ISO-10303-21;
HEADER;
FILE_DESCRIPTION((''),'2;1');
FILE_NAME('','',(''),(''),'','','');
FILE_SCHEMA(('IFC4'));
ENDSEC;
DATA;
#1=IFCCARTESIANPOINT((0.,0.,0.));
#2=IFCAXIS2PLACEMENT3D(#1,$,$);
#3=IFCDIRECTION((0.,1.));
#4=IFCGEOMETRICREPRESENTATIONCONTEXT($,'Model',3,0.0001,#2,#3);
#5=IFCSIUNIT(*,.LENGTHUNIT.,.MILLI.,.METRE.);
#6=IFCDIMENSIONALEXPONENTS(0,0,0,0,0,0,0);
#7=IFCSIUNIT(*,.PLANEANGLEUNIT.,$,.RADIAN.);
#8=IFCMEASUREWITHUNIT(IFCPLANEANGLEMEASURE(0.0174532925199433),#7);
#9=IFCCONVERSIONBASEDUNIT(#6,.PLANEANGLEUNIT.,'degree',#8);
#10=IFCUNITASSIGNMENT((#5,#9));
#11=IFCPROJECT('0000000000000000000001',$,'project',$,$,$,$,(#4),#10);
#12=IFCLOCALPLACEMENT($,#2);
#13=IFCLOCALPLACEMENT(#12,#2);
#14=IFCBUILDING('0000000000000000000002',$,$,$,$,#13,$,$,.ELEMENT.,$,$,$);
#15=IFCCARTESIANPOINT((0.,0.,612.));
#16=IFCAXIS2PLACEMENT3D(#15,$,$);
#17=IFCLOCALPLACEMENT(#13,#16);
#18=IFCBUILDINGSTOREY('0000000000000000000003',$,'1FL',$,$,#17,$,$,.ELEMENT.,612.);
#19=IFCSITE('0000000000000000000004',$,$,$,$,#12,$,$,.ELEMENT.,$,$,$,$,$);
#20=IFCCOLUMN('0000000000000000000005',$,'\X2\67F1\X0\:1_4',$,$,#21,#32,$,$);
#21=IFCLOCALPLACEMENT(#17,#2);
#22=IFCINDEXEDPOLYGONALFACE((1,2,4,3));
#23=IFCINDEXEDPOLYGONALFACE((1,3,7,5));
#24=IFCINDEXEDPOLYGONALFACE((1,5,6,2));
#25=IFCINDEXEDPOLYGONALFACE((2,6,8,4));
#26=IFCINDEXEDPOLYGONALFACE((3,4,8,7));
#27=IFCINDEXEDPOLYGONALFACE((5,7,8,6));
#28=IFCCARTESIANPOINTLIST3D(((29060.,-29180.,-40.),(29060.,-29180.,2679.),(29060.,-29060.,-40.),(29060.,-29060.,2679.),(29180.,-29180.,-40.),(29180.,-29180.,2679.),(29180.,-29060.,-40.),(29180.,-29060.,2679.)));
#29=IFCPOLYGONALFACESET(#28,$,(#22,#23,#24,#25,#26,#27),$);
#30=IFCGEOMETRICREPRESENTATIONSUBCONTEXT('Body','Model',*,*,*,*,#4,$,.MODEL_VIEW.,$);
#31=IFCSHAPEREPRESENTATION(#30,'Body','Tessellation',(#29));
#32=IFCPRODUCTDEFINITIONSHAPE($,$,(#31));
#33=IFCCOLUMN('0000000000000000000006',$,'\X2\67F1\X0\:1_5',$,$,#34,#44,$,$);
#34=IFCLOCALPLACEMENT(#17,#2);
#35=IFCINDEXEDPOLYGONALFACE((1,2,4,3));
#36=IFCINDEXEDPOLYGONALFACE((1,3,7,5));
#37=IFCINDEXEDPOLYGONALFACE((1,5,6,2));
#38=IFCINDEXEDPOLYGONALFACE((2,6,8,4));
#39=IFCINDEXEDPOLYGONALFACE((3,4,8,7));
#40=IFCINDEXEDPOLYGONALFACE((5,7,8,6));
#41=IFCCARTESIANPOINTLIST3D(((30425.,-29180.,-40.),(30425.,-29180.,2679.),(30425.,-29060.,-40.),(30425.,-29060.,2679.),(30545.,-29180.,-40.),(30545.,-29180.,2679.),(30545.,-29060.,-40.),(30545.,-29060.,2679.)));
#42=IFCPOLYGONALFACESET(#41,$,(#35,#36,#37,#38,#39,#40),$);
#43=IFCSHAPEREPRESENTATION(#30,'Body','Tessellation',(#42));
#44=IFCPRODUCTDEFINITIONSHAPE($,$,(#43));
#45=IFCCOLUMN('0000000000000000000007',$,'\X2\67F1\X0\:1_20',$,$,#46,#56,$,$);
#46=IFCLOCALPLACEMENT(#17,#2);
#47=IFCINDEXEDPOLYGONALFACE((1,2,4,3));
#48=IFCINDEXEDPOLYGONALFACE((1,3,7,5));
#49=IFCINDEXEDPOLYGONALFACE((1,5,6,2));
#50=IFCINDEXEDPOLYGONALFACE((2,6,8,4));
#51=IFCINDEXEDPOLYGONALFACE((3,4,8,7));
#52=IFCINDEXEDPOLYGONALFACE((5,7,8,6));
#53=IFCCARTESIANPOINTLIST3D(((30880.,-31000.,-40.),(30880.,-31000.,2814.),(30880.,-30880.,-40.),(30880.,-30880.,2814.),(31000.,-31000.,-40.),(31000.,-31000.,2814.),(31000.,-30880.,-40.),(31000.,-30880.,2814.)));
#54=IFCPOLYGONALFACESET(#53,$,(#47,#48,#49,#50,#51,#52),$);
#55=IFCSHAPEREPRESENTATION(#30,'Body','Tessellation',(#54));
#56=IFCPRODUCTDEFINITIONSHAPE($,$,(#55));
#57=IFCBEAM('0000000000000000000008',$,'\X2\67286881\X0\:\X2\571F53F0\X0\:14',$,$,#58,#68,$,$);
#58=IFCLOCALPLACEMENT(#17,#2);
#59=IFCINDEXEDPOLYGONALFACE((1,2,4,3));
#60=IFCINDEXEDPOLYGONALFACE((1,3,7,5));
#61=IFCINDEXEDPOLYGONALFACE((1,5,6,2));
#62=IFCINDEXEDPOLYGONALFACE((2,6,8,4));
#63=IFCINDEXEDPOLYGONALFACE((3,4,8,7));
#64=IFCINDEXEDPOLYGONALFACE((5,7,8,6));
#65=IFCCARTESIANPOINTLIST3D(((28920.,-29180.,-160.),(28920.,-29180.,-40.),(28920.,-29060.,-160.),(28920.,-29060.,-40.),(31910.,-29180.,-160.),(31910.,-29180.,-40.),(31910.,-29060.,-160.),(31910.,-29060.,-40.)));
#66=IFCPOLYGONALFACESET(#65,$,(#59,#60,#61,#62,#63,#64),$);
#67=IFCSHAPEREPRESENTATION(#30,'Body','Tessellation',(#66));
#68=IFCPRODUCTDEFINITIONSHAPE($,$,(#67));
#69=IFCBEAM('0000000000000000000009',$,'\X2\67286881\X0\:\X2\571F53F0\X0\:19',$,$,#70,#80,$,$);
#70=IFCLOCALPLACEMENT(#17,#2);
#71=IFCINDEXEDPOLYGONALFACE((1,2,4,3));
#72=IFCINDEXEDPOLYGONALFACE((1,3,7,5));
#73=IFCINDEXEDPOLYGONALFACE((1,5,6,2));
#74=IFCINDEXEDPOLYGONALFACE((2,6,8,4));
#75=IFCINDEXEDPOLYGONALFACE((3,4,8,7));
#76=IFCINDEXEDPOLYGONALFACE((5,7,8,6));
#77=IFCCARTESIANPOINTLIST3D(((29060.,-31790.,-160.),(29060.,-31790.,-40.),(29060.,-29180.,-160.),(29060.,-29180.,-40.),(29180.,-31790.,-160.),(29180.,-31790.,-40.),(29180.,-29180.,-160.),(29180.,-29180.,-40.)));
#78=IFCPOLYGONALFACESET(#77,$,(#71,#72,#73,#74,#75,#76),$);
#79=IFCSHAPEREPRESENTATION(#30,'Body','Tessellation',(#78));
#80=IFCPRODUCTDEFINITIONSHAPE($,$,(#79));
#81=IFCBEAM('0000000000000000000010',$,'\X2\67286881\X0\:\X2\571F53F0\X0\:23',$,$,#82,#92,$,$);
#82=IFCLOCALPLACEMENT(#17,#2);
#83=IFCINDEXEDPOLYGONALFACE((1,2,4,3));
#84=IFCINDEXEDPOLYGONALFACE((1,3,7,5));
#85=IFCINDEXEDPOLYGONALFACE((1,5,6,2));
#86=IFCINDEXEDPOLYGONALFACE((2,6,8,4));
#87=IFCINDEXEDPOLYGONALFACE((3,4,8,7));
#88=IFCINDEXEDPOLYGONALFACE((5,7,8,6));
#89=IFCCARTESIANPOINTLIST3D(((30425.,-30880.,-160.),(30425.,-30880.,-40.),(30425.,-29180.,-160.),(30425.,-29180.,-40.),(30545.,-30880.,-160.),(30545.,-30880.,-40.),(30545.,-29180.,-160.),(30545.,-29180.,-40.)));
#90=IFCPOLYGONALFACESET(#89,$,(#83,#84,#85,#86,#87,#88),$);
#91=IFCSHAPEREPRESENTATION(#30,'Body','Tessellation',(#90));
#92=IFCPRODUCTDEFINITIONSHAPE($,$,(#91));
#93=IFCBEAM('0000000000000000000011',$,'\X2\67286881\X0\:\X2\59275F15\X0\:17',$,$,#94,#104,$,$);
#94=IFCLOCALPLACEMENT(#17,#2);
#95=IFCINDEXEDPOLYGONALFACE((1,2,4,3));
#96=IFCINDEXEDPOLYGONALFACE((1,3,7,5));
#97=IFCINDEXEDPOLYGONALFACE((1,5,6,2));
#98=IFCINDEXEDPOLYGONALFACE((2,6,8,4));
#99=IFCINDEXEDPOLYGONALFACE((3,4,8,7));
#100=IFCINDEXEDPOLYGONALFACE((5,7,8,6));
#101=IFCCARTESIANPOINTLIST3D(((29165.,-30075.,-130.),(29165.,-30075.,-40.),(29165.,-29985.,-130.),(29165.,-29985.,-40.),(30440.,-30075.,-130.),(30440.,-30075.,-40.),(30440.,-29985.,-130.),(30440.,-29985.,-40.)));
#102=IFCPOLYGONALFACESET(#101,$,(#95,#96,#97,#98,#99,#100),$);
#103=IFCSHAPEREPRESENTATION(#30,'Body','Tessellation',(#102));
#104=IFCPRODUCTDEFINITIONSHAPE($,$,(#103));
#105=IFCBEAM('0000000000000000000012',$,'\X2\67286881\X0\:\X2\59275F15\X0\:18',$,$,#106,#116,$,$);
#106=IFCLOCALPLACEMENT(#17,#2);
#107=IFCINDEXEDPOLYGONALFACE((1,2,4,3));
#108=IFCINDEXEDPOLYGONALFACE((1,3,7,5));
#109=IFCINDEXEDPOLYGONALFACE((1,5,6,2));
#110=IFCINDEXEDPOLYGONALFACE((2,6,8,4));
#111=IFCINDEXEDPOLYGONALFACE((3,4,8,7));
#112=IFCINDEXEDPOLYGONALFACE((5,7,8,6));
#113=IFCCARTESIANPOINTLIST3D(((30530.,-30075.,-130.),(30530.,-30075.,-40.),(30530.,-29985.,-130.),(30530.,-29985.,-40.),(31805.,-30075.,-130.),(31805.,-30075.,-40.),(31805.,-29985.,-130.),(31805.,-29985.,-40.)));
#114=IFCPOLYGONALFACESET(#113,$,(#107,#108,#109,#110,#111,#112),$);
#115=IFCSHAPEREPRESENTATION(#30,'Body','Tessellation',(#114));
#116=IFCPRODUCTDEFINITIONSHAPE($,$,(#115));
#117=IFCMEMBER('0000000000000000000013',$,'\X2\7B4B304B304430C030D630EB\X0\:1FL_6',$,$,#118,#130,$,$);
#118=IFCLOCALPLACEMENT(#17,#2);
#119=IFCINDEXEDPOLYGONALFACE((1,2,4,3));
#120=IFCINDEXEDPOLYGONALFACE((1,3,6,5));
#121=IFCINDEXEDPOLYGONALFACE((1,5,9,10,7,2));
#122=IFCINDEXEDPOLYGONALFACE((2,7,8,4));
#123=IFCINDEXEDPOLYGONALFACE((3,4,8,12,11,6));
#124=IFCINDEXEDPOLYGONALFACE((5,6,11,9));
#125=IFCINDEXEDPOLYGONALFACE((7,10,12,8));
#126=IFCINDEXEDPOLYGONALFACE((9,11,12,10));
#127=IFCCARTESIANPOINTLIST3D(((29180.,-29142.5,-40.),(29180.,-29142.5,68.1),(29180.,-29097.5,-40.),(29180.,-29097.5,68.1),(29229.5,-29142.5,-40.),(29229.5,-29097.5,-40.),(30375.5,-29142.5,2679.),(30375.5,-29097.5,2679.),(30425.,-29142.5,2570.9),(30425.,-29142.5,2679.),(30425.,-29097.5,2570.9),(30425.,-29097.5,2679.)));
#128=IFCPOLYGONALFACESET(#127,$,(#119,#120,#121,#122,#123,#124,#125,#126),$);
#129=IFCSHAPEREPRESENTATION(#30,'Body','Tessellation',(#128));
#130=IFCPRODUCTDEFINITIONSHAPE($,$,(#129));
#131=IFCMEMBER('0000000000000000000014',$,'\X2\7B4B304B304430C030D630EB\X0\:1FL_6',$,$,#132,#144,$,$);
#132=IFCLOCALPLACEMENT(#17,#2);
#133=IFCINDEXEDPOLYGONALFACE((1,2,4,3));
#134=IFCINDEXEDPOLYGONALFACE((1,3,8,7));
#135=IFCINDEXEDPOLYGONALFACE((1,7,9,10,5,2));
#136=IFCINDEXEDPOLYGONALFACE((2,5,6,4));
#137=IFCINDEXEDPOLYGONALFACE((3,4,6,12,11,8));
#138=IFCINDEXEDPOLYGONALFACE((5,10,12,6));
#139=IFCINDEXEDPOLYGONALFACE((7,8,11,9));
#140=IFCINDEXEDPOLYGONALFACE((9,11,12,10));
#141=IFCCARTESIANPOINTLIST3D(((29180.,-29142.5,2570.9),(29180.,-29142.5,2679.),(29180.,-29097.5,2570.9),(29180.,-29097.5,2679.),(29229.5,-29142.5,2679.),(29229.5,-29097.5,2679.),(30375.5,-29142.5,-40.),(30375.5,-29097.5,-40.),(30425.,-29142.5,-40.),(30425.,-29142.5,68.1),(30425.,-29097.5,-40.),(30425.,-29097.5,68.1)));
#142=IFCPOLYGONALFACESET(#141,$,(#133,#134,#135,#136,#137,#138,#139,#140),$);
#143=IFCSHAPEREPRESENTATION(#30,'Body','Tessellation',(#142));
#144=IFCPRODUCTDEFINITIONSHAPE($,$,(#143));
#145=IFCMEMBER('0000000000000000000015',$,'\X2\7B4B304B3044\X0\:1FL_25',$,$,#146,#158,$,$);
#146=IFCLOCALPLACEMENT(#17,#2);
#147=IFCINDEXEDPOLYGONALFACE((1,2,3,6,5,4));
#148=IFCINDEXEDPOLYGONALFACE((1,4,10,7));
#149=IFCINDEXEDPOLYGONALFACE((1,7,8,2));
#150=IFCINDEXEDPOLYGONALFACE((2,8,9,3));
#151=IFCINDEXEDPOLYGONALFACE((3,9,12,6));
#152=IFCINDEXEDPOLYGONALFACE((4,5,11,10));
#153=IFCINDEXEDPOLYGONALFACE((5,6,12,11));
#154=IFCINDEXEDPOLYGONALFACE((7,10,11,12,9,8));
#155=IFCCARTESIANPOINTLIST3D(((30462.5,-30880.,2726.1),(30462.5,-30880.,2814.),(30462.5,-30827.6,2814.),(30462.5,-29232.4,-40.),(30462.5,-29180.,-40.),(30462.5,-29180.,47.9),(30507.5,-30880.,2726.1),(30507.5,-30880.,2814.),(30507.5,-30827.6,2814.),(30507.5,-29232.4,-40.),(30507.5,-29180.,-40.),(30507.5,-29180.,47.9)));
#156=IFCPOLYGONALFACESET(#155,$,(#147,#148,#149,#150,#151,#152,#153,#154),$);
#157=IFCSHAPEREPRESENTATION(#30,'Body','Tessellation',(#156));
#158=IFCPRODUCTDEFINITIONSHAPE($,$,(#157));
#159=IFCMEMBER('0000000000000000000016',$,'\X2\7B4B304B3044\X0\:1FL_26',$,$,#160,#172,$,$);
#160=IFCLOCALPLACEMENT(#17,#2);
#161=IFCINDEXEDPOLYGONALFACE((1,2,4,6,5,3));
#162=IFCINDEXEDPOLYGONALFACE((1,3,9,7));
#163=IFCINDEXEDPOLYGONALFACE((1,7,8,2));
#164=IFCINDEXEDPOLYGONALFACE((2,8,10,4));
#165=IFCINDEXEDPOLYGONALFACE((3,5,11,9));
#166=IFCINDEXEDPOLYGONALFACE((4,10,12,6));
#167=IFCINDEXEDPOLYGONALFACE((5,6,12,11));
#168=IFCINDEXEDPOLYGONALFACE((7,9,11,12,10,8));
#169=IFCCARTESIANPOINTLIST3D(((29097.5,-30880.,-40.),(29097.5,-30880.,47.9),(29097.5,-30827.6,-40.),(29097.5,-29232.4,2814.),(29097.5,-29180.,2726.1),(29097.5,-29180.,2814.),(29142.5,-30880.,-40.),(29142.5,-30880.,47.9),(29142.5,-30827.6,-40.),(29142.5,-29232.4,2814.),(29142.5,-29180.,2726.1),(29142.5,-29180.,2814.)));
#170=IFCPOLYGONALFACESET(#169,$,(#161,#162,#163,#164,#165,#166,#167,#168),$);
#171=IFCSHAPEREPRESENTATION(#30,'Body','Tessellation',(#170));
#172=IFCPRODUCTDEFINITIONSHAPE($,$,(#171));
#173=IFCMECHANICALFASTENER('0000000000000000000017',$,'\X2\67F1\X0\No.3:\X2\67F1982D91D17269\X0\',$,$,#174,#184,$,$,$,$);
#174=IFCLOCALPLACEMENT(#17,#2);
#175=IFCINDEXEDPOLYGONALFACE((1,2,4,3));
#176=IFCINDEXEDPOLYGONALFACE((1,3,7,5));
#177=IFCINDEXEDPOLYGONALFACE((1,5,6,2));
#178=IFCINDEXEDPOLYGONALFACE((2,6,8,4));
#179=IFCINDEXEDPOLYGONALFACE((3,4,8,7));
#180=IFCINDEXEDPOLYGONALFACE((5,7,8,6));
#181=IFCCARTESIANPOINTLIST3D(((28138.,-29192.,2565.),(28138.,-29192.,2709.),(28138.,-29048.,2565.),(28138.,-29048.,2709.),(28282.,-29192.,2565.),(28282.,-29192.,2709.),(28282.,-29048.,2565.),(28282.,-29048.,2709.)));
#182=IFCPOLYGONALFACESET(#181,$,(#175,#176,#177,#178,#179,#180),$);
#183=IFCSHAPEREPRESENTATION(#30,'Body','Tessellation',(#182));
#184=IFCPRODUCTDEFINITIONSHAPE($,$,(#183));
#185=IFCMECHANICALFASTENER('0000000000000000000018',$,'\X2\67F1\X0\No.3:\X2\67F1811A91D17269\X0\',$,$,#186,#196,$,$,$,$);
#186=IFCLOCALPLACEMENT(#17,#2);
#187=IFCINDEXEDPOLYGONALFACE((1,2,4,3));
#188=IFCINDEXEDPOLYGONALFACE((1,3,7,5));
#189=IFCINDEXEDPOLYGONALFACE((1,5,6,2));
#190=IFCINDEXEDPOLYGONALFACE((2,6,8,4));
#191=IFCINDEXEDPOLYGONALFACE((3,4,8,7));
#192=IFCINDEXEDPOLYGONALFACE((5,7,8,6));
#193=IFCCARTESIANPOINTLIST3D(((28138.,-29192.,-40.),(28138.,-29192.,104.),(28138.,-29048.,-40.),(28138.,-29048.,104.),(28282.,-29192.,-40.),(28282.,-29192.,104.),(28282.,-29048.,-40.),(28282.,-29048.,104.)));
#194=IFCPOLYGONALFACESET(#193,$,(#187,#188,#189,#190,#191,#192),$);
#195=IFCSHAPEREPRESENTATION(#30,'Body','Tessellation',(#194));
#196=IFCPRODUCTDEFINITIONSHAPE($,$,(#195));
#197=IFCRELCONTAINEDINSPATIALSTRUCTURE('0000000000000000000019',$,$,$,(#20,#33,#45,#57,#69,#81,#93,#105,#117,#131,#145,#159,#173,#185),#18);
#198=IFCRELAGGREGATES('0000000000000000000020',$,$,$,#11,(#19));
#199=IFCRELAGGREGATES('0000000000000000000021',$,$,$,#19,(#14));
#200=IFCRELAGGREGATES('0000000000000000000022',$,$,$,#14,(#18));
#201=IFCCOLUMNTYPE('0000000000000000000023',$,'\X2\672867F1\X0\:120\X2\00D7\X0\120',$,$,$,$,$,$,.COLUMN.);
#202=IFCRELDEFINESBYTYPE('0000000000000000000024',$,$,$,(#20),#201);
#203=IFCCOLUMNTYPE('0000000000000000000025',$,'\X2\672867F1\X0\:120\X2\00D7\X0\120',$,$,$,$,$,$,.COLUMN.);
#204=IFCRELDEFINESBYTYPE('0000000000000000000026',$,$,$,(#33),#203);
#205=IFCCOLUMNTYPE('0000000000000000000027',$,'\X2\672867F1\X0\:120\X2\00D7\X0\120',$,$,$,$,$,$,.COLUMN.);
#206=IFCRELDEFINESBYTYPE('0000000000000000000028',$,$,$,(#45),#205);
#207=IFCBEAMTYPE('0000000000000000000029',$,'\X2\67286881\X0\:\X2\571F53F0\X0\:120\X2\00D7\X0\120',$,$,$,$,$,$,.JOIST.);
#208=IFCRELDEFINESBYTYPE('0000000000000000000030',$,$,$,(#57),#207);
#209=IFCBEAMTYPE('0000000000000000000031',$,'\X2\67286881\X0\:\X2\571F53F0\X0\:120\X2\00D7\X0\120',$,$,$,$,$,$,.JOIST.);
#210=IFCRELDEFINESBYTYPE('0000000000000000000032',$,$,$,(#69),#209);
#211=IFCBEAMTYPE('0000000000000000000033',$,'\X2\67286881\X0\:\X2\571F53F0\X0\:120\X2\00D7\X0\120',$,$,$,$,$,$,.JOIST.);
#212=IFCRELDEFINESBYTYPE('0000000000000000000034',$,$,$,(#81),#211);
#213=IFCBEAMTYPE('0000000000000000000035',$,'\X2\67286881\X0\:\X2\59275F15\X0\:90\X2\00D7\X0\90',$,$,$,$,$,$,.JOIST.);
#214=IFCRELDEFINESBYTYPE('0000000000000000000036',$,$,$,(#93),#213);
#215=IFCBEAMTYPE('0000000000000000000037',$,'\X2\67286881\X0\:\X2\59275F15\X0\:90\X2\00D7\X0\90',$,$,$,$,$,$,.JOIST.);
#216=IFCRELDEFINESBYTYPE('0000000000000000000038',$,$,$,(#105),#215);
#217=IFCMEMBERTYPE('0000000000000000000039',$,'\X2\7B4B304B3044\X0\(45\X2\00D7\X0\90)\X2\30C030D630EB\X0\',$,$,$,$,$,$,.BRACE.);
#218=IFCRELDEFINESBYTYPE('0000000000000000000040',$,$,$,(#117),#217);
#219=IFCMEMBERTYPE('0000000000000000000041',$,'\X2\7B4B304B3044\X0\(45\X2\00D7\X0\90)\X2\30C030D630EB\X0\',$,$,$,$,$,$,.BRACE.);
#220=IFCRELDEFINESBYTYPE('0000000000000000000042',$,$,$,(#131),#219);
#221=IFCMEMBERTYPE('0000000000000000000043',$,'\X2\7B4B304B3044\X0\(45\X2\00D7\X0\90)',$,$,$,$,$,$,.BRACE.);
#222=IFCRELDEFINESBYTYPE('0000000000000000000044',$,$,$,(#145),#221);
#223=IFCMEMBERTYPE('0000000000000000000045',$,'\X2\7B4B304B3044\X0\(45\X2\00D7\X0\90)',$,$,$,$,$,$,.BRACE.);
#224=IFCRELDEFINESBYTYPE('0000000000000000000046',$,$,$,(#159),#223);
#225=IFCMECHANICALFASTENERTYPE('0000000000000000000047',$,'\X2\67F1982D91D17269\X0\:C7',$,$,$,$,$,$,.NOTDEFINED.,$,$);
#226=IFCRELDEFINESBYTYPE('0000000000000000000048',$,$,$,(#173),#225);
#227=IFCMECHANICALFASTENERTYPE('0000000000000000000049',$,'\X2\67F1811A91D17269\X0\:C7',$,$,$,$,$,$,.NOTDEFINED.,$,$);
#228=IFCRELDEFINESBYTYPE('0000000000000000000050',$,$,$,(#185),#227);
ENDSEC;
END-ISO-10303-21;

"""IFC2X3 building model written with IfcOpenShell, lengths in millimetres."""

from ifc_helpers import new_model, entity, si_unit, converted_unit, direction, frame, origin, origin_with_axes, origin_2d, place, context, subcontext, project, spatial, polyline, rectangle, outline, extrude, type_object, element, save


model = new_model("IFC2X3")

# Units and contexts
model_context = context("Model", 3, precision=0.0001, world=origin(), true_north=direction((0.0, 1.0)))
body_context = subcontext(model_context, "Body", "Model", "MODEL_VIEW")
ifc_project = project(units=[si_unit("LENGTHUNIT", "METRE", prefix="MILLI"), converted_unit("PLANEANGLEUNIT", "degree", entity("IfcPlaneAngleMeasure", 0.0174532925199433), si_unit("PLANEANGLEUNIT", "RADIAN"), dimensions=[0, 0, 0, 0, 0, 0, 0])], contexts=[model_context])

# Site, building, storey
site_placement = place(None, origin())
site = spatial("IfcSite", under=ifc_project, at=site_placement, CompositionType="ELEMENT")
building_placement = place(site_placement, origin())
building = spatial("IfcBuilding", under=site, at=building_placement, CompositionType="ELEMENT")
storey_placement = place(building_placement, frame((0.0, 0.0, 612.0)))
storey = spatial("IfcBuildingStorey", under=building, at=storey_placement, Name="1FL", CompositionType="ELEMENT", Elevation=612.0)

# Columns
column_type_1 = type_object("IfcColumnType", Name="木柱:120×120", PredefinedType="COLUMN")
column_1_placement = place(storey_placement, frame((29120.0, -29120.0, -40.0)))
element("IfcColumn", 1, at=column_1_placement, inside=storey, type_object=column_type_1, Name="柱:1_4", context=body_context, shape_type="SweptSolid", body=[
    extrude(rectangle(XDim=120.0, YDim=120.0, at=origin_2d()), origin_with_axes(), (0.0, 0.0, 1.0), 2719.0),
])
column_type_2 = type_object("IfcColumnType", Name="木柱:120×120", PredefinedType="COLUMN")
column_2_placement = place(storey_placement, frame((30485.0, -29120.0, -40.0)))
element("IfcColumn", 2, at=column_2_placement, inside=storey, type_object=column_type_2, Name="柱:1_5", context=body_context, shape_type="SweptSolid", body=[
    extrude(rectangle(XDim=120.0, YDim=120.0, at=origin_2d()), origin_with_axes(), (0.0, 0.0, 1.0), 2719.0),
])
column_type_3 = type_object("IfcColumnType", Name="木柱:120×120", PredefinedType="COLUMN")
column_3_placement = place(storey_placement, frame((30940.0, -30940.0, -40.0)))
element("IfcColumn", 3, at=column_3_placement, inside=storey, type_object=column_type_3, Name="柱:1_20", context=body_context, shape_type="SweptSolid", body=[
    extrude(rectangle(XDim=120.0, YDim=120.0, at=origin_2d()), origin_with_axes(), (0.0, 0.0, 1.0), 2854.0),
])

# Beams
beam_type_1 = type_object("IfcBeamType", Name="木梁:土台:120×120", PredefinedType="JOIST")
beam_1_placement = place(storey_placement, frame((28920.0, -29120.0, -100.0), z_axis=(1.0, 0.0, 0.0), x_axis=(0.0, 1.0, 0.0)))
element("IfcBeam", 4, at=beam_1_placement, inside=storey, type_object=beam_type_1, Name="木梁:土台:14", context=body_context, shape_type="SweptSolid", body=[
    extrude(rectangle(XDim=120.0, YDim=120.0, at=origin_2d()), origin_with_axes(), (0.0, 0.0, 1.0), 2990.0),
])
beam_type_2 = type_object("IfcBeamType", Name="木梁:土台:120×120", PredefinedType="JOIST")
beam_2_placement = place(storey_placement, frame((29120.0, -29180.0, -100.0), z_axis=(0.0, -1.0, 0.0), x_axis=(1.0, 0.0, 0.0)))
element("IfcBeam", 5, at=beam_2_placement, inside=storey, type_object=beam_type_2, Name="木梁:土台:19", context=body_context, shape_type="SweptSolid", body=[
    extrude(rectangle(XDim=120.0, YDim=120.0, at=origin_2d()), origin_with_axes(), (0.0, 0.0, 1.0), 2610.0),
])
beam_type_3 = type_object("IfcBeamType", Name="木梁:土台:120×120", PredefinedType="JOIST")
beam_3_placement = place(storey_placement, frame((30485.0, -29180.0, -100.0), z_axis=(0.0, -1.0, 0.0), x_axis=(1.0, 0.0, 0.0)))
element("IfcBeam", 6, at=beam_3_placement, inside=storey, type_object=beam_type_3, Name="木梁:土台:23", context=body_context, shape_type="SweptSolid", body=[
    extrude(rectangle(XDim=120.0, YDim=120.0, at=origin_2d()), origin_with_axes(), (0.0, 0.0, 1.0), 1700.0),
])
beam_type_4 = type_object("IfcBeamType", Name="木梁:大引:90×90", PredefinedType="JOIST")
beam_4_placement = place(storey_placement, frame((29165.0, -30030.0, -85.0), z_axis=(1.0, 0.0, 0.0), x_axis=(0.0, 1.0, 0.0)))
element("IfcBeam", 7, at=beam_4_placement, inside=storey, type_object=beam_type_4, Name="木梁:大引:17", context=body_context, shape_type="SweptSolid", body=[
    extrude(rectangle(XDim=90.0, YDim=90.0, at=origin_2d()), origin_with_axes(), (0.0, 0.0, 1.0), 1275.0),
])
beam_type_5 = type_object("IfcBeamType", Name="木梁:大引:90×90", PredefinedType="JOIST")
beam_5_placement = place(storey_placement, frame((30530.0, -30030.0, -85.0), z_axis=(1.0, 0.0, 0.0), x_axis=(0.0, 1.0, 0.0)))
element("IfcBeam", 8, at=beam_5_placement, inside=storey, type_object=beam_type_5, Name="木梁:大引:18", context=body_context, shape_type="SweptSolid", body=[
    extrude(rectangle(XDim=90.0, YDim=90.0, at=origin_2d()), origin_with_axes(), (0.0, 0.0, 1.0), 1275.0),
])

# Members
member_type_1 = type_object("IfcMemberType", Name="筋かい(45×90)ダブル", PredefinedType="BRACE")
member_1_placement = place(storey_placement, frame((29180.0, -29120.0, -40.0), z_axis=(0.416321, 0.0, 0.909218), x_axis=(-0.909218, 0.0, 0.416321)))
element("IfcMember", 9, at=member_1_placement, inside=storey, type_object=member_type_1, Name="筋かいダブル:1FL_6", context=body_context, shape_type="SweptSolid", body=[
    extrude(outline(polyline([(0.0, 0.0), (20.6, -45.0), (2892.2, -45.0), (2990.5, 0.0), (2969.9, 45.0), (98.3, 45.0), (0.0, 0.0)])), frame((0.0, -22.5, 0.0), z_axis=(0.0, 1.0, 0.0), x_axis=(0.0, 0.0, 1.0)), (0.0, 0.0, 1.0), 45.0),
])
member_type_2 = type_object("IfcMemberType", Name="筋かい(45×90)ダブル", PredefinedType="BRACE")
member_2_placement = place(storey_placement, frame((30425.0, -29120.0, -40.0), z_axis=(-0.416321, 0.0, 0.909218), x_axis=(0.909218, 0.0, 0.416321)))
element("IfcMember", 10, at=member_2_placement, inside=storey, type_object=member_type_2, Name="筋かいダブル:1FL_6", context=body_context, shape_type="SweptSolid", body=[
    extrude(outline(polyline([(0.0, 0.0), (20.6, -45.0), (2892.2, -45.0), (2990.5, 0.0), (2969.9, 45.0), (98.3, 45.0), (0.0, 0.0)])), frame((0.0, -22.5, 0.0), z_axis=(0.0, 1.0, 0.0), x_axis=(0.0, 0.0, 1.0)), (0.0, 0.0, 1.0), 45.0),
])
member_type_3 = type_object("IfcMemberType", Name="筋かい(45×90)", PredefinedType="BRACE")
member_3_placement = place(storey_placement, frame((30485.0, -29180.0, -40.0), z_axis=(0.0, -0.511748, 0.859135), x_axis=(0.0, 0.859135, 0.511748)))
element("IfcMember", 11, at=member_3_placement, inside=storey, type_object=member_type_3, Name="筋かい:1FL_25", context=body_context, shape_type="SweptSolid", body=[
    extrude(outline(polyline([(0.0, 0.0), (26.8, -45.0), (3246.4, -45.0), (3321.9, 0.0), (3295.1, 45.0), (75.5, 45.0), (0.0, 0.0)])), frame((0.0, -22.5, 0.0), z_axis=(0.0, 1.0, 0.0), x_axis=(0.0, 0.0, 1.0)), (0.0, 0.0, 1.0), 45.0),
])
member_type_4 = type_object("IfcMemberType", Name="筋かい(45×90)", PredefinedType="BRACE")
member_4_placement = place(storey_placement, frame((29120.0, -30880.0, -40.0), z_axis=(0.0, 0.511748, 0.859135), x_axis=(0.0, -0.859135, 0.511748)))
element("IfcMember", 12, at=member_4_placement, inside=storey, type_object=member_type_4, Name="筋かい:1FL_26", context=body_context, shape_type="SweptSolid", body=[
    extrude(outline(polyline([(0.0, 0.0), (26.8, -45.0), (3246.4, -45.0), (3321.9, 0.0), (3295.1, 45.0), (75.5, 45.0), (0.0, 0.0)])), frame((0.0, -22.5, 0.0), z_axis=(0.0, 1.0, 0.0), x_axis=(0.0, 0.0, 1.0)), (0.0, 0.0, 1.0), 45.0),
])

# Mechanical fasteners
mechanical_fastener_type_1 = type_object("IfcMechanicalFastenerType", Name="柱頭金物:C7")
mechanical_fastener_1_placement = place(storey_placement, frame((28210.0, -29120.0, 2565.0)))
element("IfcMechanicalFastener", 13, at=mechanical_fastener_1_placement, inside=storey, type_object=mechanical_fastener_type_1, Name="柱No.3:柱頭金物", context=body_context, shape_type="SweptSolid", body=[
    extrude(rectangle(XDim=144.0, YDim=144.0, at=origin_2d()), origin_with_axes(), (0.0, 0.0, 1.0), 144.0),
])
mechanical_fastener_type_2 = type_object("IfcMechanicalFastenerType", Name="柱脚金物:C7")
mechanical_fastener_2_placement = place(storey_placement, frame((28210.0, -29120.0, -40.0)))
element("IfcMechanicalFastener", 14, at=mechanical_fastener_2_placement, inside=storey, type_object=mechanical_fastener_type_2, Name="柱No.3:柱脚金物", context=body_context, shape_type="SweptSolid", body=[
    extrude(rectangle(XDim=144.0, YDim=144.0, at=origin_2d()), origin_with_axes(), (0.0, 0.0, 1.0), 144.0),
])

save(model, "model.ifc")
